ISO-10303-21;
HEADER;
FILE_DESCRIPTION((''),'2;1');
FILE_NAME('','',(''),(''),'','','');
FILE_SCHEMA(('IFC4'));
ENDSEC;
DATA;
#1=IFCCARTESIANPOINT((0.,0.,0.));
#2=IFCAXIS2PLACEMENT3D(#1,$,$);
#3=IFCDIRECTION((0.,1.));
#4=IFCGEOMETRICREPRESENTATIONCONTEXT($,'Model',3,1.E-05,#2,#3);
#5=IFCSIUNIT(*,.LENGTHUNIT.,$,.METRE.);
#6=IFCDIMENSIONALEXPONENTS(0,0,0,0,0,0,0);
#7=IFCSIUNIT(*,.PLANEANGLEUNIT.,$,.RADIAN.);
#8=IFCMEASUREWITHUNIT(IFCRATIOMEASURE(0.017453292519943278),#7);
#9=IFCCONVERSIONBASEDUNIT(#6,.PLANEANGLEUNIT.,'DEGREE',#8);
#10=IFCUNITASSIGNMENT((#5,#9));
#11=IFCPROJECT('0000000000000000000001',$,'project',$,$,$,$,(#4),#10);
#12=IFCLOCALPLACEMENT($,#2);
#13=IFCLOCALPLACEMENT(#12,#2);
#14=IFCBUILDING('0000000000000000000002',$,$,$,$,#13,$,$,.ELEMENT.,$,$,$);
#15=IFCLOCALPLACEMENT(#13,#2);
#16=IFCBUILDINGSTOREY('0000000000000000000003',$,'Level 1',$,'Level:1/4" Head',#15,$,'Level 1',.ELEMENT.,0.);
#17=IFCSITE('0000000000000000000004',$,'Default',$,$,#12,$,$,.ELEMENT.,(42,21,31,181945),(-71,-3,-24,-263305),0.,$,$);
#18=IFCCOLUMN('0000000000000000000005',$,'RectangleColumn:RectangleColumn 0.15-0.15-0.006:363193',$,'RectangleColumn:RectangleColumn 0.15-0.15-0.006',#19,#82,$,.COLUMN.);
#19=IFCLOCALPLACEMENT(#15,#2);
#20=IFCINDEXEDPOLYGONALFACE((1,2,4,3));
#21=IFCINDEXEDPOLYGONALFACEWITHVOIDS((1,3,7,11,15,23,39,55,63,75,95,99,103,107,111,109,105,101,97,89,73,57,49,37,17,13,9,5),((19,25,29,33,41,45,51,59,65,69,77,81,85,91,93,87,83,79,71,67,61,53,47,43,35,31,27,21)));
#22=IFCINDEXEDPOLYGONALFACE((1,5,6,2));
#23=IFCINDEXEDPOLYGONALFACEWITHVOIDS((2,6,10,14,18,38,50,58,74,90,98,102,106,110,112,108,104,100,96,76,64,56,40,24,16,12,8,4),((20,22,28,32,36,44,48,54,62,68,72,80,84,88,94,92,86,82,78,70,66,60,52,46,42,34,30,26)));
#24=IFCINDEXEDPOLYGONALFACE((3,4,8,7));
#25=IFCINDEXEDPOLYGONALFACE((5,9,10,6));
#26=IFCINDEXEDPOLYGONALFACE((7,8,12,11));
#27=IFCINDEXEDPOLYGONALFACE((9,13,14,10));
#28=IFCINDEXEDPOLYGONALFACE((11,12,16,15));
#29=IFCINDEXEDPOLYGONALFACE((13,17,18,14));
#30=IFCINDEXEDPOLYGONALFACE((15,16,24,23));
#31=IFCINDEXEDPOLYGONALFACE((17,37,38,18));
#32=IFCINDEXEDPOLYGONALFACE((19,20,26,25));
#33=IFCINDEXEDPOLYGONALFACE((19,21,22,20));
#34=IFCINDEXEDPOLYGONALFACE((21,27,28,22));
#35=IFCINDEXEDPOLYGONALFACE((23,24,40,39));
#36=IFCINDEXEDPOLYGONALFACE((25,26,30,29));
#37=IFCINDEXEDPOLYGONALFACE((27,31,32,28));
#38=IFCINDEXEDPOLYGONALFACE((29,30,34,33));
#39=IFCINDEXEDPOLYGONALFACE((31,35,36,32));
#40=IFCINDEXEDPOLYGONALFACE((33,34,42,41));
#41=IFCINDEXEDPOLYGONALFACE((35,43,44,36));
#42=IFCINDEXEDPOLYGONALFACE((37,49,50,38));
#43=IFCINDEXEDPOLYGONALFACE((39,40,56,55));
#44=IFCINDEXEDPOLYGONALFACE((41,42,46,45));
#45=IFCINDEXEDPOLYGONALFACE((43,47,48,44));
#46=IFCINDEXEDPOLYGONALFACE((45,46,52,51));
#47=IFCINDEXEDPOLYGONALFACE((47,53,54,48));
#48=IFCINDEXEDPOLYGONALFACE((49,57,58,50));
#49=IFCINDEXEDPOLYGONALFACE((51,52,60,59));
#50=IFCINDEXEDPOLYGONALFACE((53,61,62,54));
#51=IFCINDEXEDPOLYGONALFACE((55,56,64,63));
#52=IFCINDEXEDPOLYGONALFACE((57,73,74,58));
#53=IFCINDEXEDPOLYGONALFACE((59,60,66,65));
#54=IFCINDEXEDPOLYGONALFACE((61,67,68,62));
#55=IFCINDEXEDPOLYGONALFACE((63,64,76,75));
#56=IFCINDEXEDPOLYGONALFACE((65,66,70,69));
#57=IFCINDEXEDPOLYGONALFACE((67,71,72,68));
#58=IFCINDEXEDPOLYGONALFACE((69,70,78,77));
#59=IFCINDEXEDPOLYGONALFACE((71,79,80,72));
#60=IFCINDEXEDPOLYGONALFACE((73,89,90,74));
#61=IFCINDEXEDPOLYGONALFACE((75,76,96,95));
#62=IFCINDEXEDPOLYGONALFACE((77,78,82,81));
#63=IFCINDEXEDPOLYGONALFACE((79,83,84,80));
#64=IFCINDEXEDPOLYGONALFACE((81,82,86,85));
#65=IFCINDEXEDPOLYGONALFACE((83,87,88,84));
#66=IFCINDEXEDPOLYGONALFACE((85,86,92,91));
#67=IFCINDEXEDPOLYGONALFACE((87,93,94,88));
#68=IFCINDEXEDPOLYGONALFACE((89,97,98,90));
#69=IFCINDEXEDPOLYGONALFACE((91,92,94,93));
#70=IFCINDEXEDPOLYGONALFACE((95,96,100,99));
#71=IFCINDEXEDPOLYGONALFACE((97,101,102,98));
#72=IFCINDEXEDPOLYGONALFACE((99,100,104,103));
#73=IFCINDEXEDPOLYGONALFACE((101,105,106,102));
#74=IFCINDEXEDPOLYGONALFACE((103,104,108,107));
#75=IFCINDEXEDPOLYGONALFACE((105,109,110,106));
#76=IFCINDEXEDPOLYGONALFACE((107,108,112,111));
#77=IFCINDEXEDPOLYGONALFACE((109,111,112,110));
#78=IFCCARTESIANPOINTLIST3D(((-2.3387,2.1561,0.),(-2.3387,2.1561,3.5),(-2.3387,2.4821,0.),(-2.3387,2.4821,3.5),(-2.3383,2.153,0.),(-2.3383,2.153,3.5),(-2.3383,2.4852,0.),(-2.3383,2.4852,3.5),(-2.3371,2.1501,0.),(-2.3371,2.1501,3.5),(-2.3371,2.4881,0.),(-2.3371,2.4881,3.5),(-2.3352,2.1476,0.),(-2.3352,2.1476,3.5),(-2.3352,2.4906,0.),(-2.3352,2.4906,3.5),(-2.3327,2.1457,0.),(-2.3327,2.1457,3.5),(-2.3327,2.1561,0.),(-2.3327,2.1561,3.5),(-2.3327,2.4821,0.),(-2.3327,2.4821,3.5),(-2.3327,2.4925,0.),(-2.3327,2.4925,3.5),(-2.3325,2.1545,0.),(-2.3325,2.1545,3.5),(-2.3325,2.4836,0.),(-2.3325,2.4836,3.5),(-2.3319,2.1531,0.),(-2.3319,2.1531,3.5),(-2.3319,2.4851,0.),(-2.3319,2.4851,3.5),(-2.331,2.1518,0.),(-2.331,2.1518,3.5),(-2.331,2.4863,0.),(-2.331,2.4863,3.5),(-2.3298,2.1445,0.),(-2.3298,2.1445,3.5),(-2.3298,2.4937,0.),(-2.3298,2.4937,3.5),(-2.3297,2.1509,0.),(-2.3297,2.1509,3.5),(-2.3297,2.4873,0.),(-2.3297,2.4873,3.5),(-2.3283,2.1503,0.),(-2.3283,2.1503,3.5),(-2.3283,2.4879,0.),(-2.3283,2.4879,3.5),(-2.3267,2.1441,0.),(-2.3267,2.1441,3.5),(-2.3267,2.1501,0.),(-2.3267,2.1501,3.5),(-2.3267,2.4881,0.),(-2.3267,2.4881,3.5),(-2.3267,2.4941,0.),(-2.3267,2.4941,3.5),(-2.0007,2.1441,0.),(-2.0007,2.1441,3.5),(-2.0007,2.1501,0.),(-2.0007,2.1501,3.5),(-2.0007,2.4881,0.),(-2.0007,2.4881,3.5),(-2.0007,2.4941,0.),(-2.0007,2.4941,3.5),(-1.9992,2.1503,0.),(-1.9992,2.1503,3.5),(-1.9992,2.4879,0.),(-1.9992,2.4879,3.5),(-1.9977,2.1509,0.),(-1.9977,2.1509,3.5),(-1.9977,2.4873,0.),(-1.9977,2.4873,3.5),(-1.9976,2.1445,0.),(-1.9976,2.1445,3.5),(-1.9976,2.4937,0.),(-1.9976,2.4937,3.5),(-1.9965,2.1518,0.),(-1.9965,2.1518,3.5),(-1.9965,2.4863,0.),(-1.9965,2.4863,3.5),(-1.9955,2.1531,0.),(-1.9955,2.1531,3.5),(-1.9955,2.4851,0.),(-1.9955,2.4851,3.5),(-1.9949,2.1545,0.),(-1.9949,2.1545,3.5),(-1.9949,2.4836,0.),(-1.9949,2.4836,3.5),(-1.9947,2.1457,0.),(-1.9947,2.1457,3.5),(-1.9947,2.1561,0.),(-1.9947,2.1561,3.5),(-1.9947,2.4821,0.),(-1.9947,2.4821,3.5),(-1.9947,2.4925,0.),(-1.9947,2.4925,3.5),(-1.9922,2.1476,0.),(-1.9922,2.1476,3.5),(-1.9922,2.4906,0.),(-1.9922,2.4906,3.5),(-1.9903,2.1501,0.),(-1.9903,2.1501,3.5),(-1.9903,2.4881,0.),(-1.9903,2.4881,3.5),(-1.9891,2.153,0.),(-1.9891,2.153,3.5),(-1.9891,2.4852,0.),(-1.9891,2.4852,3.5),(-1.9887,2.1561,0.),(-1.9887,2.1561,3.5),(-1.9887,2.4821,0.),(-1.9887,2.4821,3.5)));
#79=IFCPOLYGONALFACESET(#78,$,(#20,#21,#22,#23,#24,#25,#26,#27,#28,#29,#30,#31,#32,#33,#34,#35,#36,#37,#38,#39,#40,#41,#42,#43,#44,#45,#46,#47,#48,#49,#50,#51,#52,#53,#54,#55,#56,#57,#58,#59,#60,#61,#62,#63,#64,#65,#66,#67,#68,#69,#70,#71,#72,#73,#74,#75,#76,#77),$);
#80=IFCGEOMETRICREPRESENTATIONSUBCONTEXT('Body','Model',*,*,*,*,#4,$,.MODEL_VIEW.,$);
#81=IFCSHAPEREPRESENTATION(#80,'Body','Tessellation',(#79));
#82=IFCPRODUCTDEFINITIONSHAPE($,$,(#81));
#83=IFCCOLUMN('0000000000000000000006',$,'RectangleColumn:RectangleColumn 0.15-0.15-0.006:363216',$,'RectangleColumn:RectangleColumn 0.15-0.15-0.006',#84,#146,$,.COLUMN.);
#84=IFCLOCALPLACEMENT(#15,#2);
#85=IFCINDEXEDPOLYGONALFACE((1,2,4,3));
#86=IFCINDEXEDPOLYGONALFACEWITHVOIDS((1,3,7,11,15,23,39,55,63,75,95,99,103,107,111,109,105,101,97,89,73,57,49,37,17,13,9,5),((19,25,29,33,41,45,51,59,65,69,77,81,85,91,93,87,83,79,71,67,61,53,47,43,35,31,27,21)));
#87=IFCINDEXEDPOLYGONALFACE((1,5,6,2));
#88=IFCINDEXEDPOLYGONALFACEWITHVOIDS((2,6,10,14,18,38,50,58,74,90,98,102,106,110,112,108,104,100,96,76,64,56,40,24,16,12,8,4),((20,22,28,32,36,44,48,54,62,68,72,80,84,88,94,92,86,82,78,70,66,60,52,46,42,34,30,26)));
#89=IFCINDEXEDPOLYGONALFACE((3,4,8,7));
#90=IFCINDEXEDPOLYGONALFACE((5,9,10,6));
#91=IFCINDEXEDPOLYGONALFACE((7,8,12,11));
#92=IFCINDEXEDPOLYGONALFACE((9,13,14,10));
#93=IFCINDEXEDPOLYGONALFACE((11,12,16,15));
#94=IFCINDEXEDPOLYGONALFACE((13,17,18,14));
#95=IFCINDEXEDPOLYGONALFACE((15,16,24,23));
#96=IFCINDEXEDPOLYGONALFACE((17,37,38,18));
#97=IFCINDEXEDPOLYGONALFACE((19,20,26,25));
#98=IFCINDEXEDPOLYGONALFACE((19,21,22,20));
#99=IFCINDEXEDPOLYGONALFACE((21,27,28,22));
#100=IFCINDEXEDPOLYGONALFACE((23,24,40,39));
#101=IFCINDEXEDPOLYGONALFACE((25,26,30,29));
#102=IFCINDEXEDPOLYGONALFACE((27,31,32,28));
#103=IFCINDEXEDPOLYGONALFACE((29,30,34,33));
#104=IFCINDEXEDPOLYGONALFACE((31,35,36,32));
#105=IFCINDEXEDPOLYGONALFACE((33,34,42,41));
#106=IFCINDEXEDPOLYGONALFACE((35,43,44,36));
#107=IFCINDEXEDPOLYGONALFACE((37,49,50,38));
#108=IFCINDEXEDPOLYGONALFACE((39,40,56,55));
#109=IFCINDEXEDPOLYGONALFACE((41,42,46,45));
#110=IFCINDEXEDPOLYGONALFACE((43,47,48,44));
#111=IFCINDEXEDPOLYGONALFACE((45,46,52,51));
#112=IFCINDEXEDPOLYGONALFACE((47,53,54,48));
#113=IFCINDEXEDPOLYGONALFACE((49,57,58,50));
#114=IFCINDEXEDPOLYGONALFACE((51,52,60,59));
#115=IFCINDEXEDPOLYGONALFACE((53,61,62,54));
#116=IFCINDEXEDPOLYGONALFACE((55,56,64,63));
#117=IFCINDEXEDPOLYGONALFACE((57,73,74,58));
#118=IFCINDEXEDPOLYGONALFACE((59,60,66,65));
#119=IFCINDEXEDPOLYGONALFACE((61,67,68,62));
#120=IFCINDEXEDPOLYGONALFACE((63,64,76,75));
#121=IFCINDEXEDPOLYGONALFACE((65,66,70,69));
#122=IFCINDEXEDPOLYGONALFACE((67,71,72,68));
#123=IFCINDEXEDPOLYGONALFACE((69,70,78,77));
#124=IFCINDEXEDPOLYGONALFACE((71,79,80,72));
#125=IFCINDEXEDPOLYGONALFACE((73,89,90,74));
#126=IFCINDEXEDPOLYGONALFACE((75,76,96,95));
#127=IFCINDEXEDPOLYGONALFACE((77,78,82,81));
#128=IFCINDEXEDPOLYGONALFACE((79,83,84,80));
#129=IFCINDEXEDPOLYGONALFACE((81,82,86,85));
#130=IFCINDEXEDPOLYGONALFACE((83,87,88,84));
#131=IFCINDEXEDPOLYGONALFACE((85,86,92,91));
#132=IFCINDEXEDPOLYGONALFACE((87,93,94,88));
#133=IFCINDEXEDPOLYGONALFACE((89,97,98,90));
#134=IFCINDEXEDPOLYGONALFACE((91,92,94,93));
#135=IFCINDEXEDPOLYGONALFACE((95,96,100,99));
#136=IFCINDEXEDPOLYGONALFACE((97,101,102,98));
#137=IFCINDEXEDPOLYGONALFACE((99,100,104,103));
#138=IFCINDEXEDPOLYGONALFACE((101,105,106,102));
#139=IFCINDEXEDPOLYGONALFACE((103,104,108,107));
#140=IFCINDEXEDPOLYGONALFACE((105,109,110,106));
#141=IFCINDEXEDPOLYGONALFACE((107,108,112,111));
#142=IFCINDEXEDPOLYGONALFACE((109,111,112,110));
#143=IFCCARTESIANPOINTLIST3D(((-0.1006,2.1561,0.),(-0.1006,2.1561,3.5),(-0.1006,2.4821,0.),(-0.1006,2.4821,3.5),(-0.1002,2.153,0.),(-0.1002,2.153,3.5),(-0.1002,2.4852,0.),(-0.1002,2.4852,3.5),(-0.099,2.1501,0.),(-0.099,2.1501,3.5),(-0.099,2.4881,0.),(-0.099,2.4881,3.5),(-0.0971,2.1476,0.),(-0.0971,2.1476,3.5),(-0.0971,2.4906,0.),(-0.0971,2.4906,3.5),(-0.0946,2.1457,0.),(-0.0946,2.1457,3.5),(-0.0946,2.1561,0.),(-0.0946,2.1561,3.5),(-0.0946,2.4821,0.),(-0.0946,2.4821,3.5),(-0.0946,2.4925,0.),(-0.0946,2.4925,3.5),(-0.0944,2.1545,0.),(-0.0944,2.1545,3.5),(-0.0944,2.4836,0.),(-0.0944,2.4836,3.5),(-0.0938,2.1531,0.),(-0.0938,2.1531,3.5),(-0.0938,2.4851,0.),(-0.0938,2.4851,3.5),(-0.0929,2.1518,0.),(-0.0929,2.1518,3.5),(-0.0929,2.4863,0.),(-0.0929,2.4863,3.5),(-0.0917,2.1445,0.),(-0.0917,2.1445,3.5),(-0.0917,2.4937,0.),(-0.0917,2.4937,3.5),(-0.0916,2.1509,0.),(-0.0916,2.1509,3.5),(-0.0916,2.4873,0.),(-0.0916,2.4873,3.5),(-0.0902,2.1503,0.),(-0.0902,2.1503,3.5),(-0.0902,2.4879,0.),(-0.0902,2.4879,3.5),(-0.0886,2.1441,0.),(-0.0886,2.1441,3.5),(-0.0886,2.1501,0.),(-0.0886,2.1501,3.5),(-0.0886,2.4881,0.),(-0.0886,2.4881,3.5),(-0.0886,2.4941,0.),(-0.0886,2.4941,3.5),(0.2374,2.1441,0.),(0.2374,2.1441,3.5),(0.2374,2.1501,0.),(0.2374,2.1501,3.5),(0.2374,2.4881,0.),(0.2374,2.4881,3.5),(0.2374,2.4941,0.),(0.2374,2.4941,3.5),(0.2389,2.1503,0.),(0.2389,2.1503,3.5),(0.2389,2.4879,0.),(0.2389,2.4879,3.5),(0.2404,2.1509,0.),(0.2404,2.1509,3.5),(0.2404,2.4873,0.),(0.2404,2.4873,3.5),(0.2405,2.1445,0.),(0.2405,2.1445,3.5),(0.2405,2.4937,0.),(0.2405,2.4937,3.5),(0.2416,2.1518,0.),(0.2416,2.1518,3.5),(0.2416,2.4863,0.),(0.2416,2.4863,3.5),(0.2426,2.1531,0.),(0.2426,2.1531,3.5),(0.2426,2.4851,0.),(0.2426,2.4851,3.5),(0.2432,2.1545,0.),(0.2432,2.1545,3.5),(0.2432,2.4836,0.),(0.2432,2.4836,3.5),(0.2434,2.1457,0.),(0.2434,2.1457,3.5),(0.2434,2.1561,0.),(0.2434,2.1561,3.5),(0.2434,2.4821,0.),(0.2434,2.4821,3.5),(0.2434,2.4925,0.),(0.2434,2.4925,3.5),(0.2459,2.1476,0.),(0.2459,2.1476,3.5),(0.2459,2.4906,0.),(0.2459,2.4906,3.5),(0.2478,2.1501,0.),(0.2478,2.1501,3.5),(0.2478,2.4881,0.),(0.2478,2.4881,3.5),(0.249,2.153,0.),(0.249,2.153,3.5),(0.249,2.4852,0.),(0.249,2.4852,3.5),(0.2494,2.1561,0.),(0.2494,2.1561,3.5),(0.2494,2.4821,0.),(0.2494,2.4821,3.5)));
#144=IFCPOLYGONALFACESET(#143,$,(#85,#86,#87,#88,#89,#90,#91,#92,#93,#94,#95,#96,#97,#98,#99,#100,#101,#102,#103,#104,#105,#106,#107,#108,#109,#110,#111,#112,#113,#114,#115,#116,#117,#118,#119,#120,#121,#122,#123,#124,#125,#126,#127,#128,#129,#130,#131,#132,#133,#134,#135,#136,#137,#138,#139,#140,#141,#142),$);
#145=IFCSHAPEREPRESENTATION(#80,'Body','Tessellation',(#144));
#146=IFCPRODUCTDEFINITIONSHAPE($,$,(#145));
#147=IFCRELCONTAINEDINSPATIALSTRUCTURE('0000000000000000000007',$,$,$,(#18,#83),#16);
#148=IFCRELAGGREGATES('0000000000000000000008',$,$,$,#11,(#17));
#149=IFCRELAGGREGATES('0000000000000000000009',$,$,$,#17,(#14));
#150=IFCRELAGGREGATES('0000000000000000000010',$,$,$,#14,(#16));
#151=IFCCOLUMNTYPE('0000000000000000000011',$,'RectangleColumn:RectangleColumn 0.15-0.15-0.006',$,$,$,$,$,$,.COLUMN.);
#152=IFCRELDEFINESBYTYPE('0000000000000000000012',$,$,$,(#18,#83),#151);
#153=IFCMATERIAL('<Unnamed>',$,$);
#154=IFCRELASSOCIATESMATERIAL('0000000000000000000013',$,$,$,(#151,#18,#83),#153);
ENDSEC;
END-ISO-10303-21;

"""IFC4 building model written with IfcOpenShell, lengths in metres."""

from ifc_helpers import new_model, entity, si_unit, converted_unit, direction, frame, origin, place, context, subcontext, project, spatial, line, arc, indexed_curve, outline, extrude, source, transform, mapped, material, type_object, type_shapes, element, save


model = new_model("IFC4")

# Units and contexts
model_context = context("Model", 3, precision=1e-05, world=origin(), true_north=direction((0.0, 1.0)))
body_context = subcontext(model_context, "Body", "Model", "MODEL_VIEW")
ifc_project = project(units=[si_unit("LENGTHUNIT", "METRE"), converted_unit("PLANEANGLEUNIT", "DEGREE", entity("IfcRatioMeasure", 0.017453292519943278), si_unit("PLANEANGLEUNIT", "RADIAN"), dimensions=[0, 0, 0, 0, 0, 0, 0])], contexts=[model_context])

# Site, building, storey
site_placement = place(None, origin())
site = spatial("IfcSite", under=ifc_project, at=site_placement, Name="Default", CompositionType="ELEMENT", RefLatitude=(42, 21, 31, 181945), RefLongitude=(-71, -3, -24, -263305), RefElevation=0.0)
building_placement = place(site_placement, origin())
building = spatial("IfcBuilding", under=site, at=building_placement, CompositionType="ELEMENT")
storey_placement = place(building_placement, origin())
storey = spatial("IfcBuildingStorey", under=building, at=storey_placement, Name="Level 1", ObjectType="Level:1/4\" Head", LongName="Level 1", CompositionType="ELEMENT", Elevation=0.0)

# Columns
ifc_material_1 = material(Name="<Unnamed>")
column_type = type_object("IfcColumnType", Name="RectangleColumn:RectangleColumn 0.15-0.15-0.006", PredefinedType="COLUMN", material=ifc_material_1)
shared_shape = source(origin(), body_context, "Body", "SweptSolid", [
    extrude(outline(indexed_curve([(-0.163, -0.175), (0.163, -0.175), (0.1715, -0.1715), (0.175, -0.163), (0.175, 0.163), (0.1715, 0.1715), (0.163, 0.175), (-0.163, 0.175), (-0.1715, 0.1715), (-0.175, 0.163), (-0.175, -0.163), (-0.1715, -0.1715)], segments=[line(1, 2), arc(2, 3, 4), line(4, 5), arc(5, 6, 7), line(7, 8), arc(8, 9, 10), line(10, 11), arc(11, 12, 1)], self_intersect=False), holes=[indexed_curve([(-0.163, -0.169), (-0.1672, -0.1672), (-0.169, -0.163), (-0.169, 0.163), (-0.1672, 0.1672), (-0.163, 0.169), (0.163, 0.169), (0.1672, 0.1672), (0.169, 0.163), (0.169, -0.163), (0.1672, -0.1672), (0.163, -0.169)], segments=[arc(1, 2, 3), line(3, 4), arc(4, 5, 6), line(6, 7), arc(7, 8, 9), line(9, 10), arc(10, 11, 12), line(12, 1)], self_intersect=False)]), frame((0.0, 0.0, 0.0), z_axis=(0.0, 0.0, 1.0), x_axis=(-1.0, 0.0, 0.0)), (0.0, 0.0, 1.0), 3.5),
])
type_shapes(column_type, [shared_shape])
for number, where, name in (
    (1, (-2.1637, 2.3191, 0.0), "RectangleColumn:RectangleColumn 0.15-0.15-0.006:363193"),
    (2, (0.0744, 2.3191, 0.0), "RectangleColumn:RectangleColumn 0.15-0.15-0.006:363216"),
):
    element("IfcColumn", number, at=place(storey_placement, frame(where)), inside=storey, type_object=column_type, material=ifc_material_1, Name=name, ObjectType="RectangleColumn:RectangleColumn 0.15-0.15-0.006", PredefinedType="COLUMN", context=body_context, shape_type="MappedRepresentation", body=[
        mapped(shared_shape, transform((0.0, 0.0, 0.0), scale=1.0)),
    ])

save(model, "model.ifc")
